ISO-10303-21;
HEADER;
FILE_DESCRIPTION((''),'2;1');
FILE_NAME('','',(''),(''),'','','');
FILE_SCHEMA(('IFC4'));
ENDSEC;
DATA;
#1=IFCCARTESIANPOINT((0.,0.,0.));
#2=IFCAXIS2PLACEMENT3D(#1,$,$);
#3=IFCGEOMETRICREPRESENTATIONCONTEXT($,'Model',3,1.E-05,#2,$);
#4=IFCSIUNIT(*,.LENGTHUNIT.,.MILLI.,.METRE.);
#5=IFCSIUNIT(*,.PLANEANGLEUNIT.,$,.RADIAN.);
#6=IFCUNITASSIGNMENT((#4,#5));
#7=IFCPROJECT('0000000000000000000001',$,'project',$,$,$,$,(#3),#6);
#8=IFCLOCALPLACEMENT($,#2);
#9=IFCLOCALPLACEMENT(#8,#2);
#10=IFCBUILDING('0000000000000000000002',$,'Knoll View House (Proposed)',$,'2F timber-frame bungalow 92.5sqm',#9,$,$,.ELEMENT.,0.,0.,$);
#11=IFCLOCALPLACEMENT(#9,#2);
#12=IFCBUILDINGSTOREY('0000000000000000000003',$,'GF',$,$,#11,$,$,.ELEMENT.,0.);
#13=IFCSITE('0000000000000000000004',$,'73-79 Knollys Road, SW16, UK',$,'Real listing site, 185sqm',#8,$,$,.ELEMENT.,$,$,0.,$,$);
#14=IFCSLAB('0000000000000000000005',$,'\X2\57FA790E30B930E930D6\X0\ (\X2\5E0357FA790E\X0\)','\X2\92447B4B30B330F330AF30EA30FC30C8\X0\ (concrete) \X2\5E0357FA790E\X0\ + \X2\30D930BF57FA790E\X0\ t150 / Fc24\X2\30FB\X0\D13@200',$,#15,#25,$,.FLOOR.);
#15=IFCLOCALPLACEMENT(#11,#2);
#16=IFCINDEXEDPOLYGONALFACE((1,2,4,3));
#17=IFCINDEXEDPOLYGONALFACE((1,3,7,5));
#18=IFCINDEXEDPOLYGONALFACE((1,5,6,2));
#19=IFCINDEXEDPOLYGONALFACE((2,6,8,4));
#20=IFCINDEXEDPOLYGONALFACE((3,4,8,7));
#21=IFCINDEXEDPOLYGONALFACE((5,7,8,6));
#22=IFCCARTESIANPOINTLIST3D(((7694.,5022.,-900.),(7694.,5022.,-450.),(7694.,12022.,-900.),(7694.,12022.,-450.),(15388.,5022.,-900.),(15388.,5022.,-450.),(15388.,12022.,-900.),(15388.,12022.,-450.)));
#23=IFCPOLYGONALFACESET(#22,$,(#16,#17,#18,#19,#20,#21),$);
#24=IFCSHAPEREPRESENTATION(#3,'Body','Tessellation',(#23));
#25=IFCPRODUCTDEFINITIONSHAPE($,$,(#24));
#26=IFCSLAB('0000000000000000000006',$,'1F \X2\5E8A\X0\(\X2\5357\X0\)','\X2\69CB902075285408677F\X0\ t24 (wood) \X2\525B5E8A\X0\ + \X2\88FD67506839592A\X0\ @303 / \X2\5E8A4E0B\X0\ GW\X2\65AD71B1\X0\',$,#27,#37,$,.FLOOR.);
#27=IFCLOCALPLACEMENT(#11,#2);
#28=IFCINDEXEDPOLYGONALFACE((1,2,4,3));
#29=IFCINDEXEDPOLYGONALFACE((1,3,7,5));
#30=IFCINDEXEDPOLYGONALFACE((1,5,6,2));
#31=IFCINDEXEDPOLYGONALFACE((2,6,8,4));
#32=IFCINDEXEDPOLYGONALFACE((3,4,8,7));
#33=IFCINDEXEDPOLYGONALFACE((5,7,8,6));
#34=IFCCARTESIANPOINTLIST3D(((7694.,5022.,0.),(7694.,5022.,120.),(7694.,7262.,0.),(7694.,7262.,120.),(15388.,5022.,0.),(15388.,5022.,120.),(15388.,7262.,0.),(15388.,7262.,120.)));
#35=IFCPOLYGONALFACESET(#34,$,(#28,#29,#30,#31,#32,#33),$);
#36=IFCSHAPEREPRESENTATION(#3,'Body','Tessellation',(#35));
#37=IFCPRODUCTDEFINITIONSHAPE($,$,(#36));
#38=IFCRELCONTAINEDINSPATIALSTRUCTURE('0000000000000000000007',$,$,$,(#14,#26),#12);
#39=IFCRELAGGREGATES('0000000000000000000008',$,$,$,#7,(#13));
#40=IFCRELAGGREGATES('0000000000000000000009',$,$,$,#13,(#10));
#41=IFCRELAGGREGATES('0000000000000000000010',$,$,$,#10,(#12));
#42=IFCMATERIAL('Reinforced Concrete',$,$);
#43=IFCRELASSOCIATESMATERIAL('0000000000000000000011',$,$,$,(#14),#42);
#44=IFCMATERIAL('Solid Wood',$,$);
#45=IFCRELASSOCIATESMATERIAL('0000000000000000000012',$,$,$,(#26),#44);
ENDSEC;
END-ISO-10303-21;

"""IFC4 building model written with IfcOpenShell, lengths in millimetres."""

from ifc_helpers import new_model, si_unit, frame, frame_2d, origin, place, context, project, spatial, rectangle, extrude, material, element, save


model = new_model("IFC4")

# Units and contexts
model_context = context("Model", 3, precision=1e-05, world=origin())
ifc_project = project(units=[si_unit("LENGTHUNIT", "METRE", prefix="MILLI"), si_unit("PLANEANGLEUNIT", "RADIAN")], contexts=[model_context])

# Site, building, storey
site_placement = place(None, origin())
site = spatial("IfcSite", under=ifc_project, at=site_placement, Name="73-79 Knollys Road, SW16, UK", ObjectType="Real listing site, 185sqm", CompositionType="ELEMENT", RefElevation=0.0)
building_placement = place(site_placement, origin())
building = spatial("IfcBuilding", under=site, at=building_placement, Name="Knoll View House (Proposed)", ObjectType="2F timber-frame bungalow 92.5sqm", CompositionType="ELEMENT", ElevationOfRefHeight=0.0, ElevationOfTerrain=0.0)
storey_placement = place(building_placement, origin())
storey = spatial("IfcBuildingStorey", under=building, at=storey_placement, Name="GF", CompositionType="ELEMENT", Elevation=0.0)

# Slabs
ifc_material_1 = material(Name="Reinforced Concrete")
slab_1_placement = place(storey_placement, frame((3847.0, 2511.0, -450.0)))
element("IfcSlab", 1, at=slab_1_placement, inside=storey, material=ifc_material_1, Name="基礎スラブ (布基礎)", Description="鉄筋コンクリート (concrete) 布基礎 + ベタ基礎 t150 / Fc24・D13@200", PredefinedType="FLOOR", context=model_context, shape_type="SweptSolid", body=[
    extrude(rectangle(XDim=7694.0, YDim=7000.0, at=frame_2d((3847.0, 3500.0))), frame((3847.0, 2511.0, -450.0)), (0.0, 0.0, 1.0), 450.0),
])
ifc_material_2 = material(Name="Solid Wood")
slab_2_placement = place(storey_placement, frame((3847.0, 2511.0, 0.0)))
element("IfcSlab", 2, at=slab_2_placement, inside=storey, material=ifc_material_2, Name="1F 床(南)", Description="構造用合板 t24 (wood) 剛床 + 製材根太 @303 / 床下 GW断熱", PredefinedType="FLOOR", context=model_context, shape_type="SweptSolid", body=[
    extrude(rectangle(XDim=7694.0, YDim=2240.0, at=frame_2d((3847.0, 1120.0))), frame((3847.0, 2511.0, 0.0)), (0.0, 0.0, 1.0), 120.0),
])

save(model, "model.ifc")
